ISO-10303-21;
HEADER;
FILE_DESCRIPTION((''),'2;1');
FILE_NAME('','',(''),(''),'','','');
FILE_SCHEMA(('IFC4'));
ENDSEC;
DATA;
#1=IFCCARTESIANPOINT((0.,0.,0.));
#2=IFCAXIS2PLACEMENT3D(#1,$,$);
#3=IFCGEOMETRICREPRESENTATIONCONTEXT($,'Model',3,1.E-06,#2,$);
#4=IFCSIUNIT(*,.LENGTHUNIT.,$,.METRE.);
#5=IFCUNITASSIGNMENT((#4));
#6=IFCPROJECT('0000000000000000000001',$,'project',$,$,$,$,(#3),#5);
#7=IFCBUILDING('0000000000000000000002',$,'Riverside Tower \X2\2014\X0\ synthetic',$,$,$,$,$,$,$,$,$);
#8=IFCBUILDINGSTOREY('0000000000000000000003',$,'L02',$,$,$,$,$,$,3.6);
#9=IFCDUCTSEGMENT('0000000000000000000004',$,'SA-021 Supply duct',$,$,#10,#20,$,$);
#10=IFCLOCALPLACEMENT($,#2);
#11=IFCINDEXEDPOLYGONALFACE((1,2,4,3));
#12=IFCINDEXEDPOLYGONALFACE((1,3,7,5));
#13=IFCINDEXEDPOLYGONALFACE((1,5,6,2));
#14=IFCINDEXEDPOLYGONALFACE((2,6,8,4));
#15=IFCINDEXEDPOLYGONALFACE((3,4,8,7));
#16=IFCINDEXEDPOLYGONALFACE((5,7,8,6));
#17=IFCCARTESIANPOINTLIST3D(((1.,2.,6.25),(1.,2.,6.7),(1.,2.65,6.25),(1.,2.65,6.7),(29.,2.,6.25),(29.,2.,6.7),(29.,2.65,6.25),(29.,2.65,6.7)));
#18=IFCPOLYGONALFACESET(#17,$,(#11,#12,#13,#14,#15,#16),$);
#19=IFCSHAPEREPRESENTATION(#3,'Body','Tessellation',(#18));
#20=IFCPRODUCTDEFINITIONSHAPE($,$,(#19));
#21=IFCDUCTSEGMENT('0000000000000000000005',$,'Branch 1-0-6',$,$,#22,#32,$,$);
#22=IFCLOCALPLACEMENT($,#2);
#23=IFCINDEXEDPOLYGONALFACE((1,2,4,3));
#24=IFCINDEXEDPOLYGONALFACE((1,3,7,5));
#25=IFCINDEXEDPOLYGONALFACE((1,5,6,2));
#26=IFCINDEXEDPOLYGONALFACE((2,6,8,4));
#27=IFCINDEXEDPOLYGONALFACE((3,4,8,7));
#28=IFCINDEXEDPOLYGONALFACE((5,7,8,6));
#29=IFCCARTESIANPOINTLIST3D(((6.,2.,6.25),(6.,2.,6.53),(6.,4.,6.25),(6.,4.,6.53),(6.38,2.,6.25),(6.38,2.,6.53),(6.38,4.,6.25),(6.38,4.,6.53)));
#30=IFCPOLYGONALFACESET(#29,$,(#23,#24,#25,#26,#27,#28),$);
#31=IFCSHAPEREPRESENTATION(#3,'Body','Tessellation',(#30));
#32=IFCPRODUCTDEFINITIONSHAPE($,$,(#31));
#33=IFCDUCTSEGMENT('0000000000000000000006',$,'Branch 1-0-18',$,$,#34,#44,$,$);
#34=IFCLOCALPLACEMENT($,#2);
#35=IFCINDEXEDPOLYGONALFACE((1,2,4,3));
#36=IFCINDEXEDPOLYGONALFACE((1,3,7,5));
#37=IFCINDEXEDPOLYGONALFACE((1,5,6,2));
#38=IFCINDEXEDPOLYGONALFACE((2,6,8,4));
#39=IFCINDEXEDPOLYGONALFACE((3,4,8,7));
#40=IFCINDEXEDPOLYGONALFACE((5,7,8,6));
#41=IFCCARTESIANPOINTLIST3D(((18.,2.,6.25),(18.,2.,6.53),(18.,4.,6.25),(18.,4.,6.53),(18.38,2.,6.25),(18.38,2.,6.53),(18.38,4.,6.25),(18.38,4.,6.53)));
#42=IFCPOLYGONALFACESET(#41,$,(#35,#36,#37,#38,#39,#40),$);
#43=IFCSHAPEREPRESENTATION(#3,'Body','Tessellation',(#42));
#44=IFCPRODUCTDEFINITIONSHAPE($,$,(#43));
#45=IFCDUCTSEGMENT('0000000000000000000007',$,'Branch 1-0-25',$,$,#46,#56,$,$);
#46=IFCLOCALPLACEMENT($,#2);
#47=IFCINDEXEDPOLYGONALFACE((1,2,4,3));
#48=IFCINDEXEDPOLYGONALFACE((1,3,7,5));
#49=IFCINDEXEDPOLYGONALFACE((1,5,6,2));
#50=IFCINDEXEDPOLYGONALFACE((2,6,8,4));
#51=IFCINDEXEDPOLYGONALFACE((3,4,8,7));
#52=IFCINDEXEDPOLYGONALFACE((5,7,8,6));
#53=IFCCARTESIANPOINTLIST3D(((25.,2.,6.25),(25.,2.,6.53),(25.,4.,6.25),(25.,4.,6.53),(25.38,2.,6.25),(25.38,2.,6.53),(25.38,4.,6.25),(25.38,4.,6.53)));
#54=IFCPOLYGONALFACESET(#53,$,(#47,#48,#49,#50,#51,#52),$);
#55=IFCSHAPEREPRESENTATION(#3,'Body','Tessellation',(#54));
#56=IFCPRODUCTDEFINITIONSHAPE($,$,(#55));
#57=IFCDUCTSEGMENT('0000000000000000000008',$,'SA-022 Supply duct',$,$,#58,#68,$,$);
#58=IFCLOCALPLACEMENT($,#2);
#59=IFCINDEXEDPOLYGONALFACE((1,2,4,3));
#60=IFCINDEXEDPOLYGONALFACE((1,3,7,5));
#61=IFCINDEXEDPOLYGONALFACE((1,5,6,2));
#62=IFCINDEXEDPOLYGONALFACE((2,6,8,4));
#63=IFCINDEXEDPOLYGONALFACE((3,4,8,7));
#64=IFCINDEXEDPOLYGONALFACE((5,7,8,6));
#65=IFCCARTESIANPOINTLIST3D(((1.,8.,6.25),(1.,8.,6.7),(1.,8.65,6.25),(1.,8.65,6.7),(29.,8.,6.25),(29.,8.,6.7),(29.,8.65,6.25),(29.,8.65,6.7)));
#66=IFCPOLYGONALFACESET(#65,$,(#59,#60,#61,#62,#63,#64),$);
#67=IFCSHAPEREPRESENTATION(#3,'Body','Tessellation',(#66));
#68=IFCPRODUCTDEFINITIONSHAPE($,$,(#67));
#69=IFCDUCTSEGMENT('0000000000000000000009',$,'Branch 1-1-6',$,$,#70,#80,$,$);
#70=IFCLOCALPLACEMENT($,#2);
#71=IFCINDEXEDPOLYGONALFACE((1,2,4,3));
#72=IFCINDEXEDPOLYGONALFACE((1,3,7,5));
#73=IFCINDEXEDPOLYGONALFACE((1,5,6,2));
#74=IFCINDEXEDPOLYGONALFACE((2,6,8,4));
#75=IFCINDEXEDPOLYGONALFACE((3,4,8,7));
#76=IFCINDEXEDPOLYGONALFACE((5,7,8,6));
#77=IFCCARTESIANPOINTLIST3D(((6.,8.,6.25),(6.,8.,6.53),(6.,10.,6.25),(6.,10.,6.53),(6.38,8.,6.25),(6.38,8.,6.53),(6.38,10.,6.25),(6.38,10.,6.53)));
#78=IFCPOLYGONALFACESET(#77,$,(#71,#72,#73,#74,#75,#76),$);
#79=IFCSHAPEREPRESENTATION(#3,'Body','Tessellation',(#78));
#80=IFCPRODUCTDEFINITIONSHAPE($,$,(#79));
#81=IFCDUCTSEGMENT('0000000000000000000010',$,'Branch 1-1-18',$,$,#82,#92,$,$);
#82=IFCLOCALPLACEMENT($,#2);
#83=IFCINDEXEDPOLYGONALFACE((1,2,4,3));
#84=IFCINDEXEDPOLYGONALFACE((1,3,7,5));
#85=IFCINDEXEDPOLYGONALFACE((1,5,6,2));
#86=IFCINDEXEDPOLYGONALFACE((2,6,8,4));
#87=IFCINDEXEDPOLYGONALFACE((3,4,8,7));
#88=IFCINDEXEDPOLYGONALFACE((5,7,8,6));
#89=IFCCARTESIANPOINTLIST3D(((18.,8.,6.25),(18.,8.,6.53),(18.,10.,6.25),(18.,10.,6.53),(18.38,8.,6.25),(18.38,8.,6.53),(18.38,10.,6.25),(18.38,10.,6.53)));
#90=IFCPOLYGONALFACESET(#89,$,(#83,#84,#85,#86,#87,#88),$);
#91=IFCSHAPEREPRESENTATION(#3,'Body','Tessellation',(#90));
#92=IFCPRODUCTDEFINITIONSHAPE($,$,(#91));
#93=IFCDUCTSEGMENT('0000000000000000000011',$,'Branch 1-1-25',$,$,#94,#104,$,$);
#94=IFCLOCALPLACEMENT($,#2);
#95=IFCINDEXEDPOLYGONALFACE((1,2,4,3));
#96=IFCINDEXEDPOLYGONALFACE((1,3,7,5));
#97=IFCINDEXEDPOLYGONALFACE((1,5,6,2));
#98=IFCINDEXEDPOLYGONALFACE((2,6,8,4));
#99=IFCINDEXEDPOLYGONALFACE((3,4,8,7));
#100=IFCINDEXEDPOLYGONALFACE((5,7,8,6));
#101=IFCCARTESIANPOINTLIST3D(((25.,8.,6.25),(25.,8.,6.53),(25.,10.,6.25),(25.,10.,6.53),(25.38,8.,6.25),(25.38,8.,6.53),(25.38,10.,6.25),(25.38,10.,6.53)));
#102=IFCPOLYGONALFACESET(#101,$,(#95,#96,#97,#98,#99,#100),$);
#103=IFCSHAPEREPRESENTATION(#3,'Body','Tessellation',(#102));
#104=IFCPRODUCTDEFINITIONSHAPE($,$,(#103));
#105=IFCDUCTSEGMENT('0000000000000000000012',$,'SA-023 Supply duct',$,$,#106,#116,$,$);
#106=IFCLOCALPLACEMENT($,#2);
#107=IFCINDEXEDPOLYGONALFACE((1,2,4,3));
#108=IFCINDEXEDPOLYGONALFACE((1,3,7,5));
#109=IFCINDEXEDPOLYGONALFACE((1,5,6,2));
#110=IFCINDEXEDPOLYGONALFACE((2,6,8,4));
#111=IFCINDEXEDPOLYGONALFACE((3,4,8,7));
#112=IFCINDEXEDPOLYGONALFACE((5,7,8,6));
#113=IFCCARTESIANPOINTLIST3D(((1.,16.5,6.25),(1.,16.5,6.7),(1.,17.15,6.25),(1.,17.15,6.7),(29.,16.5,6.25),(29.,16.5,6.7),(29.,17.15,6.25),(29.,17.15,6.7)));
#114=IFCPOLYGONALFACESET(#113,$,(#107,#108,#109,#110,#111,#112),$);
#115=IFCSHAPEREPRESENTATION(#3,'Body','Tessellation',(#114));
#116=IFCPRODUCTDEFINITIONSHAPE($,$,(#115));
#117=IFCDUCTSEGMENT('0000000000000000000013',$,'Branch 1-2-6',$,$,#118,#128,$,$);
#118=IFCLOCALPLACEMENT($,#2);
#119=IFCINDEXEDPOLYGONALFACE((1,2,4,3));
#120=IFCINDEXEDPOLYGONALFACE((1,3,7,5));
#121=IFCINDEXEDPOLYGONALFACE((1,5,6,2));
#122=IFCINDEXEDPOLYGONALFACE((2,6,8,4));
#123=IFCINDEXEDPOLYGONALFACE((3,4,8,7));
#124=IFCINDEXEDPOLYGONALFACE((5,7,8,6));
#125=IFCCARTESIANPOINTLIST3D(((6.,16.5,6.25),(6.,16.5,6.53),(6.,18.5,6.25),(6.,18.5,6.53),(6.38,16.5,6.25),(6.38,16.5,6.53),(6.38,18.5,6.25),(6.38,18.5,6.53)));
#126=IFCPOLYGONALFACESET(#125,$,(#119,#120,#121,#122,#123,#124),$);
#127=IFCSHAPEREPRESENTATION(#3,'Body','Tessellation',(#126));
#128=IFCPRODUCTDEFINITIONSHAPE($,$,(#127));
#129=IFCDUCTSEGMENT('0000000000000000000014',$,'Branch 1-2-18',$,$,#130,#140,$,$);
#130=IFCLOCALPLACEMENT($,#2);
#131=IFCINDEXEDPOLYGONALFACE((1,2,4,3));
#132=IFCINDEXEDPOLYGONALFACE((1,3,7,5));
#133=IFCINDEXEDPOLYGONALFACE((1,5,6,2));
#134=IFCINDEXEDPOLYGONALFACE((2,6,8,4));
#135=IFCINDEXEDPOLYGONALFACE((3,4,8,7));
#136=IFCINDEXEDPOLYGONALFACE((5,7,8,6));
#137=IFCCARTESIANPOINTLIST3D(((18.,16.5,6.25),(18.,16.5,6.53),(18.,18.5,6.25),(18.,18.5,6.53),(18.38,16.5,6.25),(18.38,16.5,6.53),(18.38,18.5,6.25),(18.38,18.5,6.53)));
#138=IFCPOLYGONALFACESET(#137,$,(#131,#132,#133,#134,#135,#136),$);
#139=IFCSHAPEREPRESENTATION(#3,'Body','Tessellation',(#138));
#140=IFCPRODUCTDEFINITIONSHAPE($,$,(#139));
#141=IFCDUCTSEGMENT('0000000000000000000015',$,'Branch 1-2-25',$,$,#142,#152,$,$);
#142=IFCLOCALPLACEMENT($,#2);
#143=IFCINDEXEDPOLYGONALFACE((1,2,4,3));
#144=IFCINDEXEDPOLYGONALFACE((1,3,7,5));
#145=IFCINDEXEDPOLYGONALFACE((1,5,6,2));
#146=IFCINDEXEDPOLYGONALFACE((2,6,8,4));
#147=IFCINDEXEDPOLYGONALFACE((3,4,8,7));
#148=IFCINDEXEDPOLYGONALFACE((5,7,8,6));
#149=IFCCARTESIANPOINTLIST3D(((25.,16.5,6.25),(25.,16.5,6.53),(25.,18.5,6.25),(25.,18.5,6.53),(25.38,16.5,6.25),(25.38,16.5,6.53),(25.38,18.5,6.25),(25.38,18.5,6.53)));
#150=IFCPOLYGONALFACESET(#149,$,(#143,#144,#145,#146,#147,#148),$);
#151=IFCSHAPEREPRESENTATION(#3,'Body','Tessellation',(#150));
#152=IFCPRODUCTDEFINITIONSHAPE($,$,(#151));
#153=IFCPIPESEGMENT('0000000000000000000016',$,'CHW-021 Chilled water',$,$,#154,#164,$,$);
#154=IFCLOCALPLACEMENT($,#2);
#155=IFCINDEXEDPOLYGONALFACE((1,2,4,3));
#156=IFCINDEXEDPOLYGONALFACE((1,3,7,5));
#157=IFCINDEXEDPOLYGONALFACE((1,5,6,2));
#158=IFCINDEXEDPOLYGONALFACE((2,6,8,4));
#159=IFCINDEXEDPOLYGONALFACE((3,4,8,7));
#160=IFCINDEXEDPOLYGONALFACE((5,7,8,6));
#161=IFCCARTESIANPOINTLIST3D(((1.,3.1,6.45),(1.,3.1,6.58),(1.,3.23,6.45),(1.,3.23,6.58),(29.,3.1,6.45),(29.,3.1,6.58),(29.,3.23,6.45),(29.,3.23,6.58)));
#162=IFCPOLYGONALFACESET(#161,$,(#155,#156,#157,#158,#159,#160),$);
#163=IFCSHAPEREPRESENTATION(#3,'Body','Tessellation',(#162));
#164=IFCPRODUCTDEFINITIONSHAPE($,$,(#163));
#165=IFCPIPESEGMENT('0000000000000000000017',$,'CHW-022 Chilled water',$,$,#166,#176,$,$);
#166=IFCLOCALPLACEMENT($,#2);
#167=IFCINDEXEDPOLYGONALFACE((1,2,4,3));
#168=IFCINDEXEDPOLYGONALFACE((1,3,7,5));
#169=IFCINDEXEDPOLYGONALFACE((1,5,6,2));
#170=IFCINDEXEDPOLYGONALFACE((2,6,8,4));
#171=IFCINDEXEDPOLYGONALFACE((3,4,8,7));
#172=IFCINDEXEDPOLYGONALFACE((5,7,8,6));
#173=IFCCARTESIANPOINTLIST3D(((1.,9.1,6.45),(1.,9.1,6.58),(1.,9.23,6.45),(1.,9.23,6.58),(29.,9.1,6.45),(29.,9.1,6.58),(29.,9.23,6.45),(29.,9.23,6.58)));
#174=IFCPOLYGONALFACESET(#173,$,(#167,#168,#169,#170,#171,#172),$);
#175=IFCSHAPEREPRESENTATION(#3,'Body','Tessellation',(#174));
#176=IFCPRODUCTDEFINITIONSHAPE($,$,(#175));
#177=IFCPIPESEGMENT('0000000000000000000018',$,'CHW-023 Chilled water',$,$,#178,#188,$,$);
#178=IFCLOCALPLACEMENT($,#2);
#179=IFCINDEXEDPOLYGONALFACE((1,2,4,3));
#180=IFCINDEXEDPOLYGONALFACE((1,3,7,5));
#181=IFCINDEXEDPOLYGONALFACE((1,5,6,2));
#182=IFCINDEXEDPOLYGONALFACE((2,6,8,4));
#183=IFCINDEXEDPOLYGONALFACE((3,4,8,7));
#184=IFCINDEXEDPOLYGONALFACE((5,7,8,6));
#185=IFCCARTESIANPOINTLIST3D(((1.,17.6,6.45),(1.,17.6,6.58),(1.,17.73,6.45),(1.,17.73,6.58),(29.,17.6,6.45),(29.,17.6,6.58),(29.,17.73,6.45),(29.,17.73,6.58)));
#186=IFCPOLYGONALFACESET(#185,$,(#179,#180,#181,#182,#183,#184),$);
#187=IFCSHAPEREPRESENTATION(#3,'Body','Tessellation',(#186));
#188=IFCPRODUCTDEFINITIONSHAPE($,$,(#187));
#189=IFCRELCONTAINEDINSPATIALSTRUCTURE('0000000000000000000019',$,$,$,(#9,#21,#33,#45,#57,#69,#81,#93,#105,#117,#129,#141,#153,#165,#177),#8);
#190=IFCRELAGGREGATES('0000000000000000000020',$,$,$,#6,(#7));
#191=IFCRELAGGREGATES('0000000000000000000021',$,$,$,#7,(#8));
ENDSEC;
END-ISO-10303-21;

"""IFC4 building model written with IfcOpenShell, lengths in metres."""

from ifc_helpers import new_model, si_unit, frame, origin, place, context, project, spatial, rectangle, extrude, element, save


model = new_model("IFC4")

# Units and contexts
model_context = context("Model", 3, precision=1e-06, world=origin())
ifc_project = project(units=[si_unit("LENGTHUNIT", "METRE")], contexts=[model_context])

# Building, storey
building = spatial("IfcBuilding", under=ifc_project, Name="Riverside Tower — synthetic")
storey = spatial("IfcBuildingStorey", under=building, Name="L02", Elevation=3.6)

# Duct segments
duct_segment_1_placement = place(None, frame((15.0, 2.325, 6.25)))
element("IfcDuctSegment", 1, at=duct_segment_1_placement, inside=storey, Name="SA-021 Supply duct", context=model_context, shape_type="SweptSolid", body=[
    extrude(rectangle(XDim=28.0, YDim=0.65), origin(), (0.0, 0.0, 1.0), 0.45),
])
for number, where, name in (
    (2, (6.19, 3.0, 6.25), "Branch 1-0-6"),
    (3, (18.19, 3.0, 6.25), "Branch 1-0-18"),
    (4, (25.19, 3.0, 6.25), "Branch 1-0-25"),
):
    element("IfcDuctSegment", number, at=place(None, frame(where)), inside=storey, Name=name, context=model_context, shape_type="SweptSolid", body=[
        extrude(rectangle(XDim=0.38, YDim=2.0), origin(), (0.0, 0.0, 1.0), 0.28),
    ])
duct_segment_2_placement = place(None, frame((15.0, 8.325, 6.25)))
element("IfcDuctSegment", 5, at=duct_segment_2_placement, inside=storey, Name="SA-022 Supply duct", context=model_context, shape_type="SweptSolid", body=[
    extrude(rectangle(XDim=28.0, YDim=0.65), origin(), (0.0, 0.0, 1.0), 0.45),
])
for number, where, name in (
    (6, (6.19, 9.0, 6.25), "Branch 1-1-6"),
    (7, (18.19, 9.0, 6.25), "Branch 1-1-18"),
    (8, (25.19, 9.0, 6.25), "Branch 1-1-25"),
):
    element("IfcDuctSegment", number, at=place(None, frame(where)), inside=storey, Name=name, context=model_context, shape_type="SweptSolid", body=[
        extrude(rectangle(XDim=0.38, YDim=2.0), origin(), (0.0, 0.0, 1.0), 0.28),
    ])
duct_segment_3_placement = place(None, frame((15.0, 16.825, 6.25)))
element("IfcDuctSegment", 9, at=duct_segment_3_placement, inside=storey, Name="SA-023 Supply duct", context=model_context, shape_type="SweptSolid", body=[
    extrude(rectangle(XDim=28.0, YDim=0.65), origin(), (0.0, 0.0, 1.0), 0.45),
])
for number, where, name in (
    (10, (6.19, 17.5, 6.25), "Branch 1-2-6"),
    (11, (18.19, 17.5, 6.25), "Branch 1-2-18"),
    (12, (25.19, 17.5, 6.25), "Branch 1-2-25"),
):
    element("IfcDuctSegment", number, at=place(None, frame(where)), inside=storey, Name=name, context=model_context, shape_type="SweptSolid", body=[
        extrude(rectangle(XDim=0.38, YDim=2.0), origin(), (0.0, 0.0, 1.0), 0.28),
    ])

# Pipe segments
for number, where, name in (
    (13, (15.0, 3.165, 6.45), "CHW-021 Chilled water"),
    (14, (15.0, 9.165, 6.45), "CHW-022 Chilled water"),
    (15, (15.0, 17.665, 6.45), "CHW-023 Chilled water"),
):
    element("IfcPipeSegment", number, at=place(None, frame(where)), inside=storey, Name=name, context=model_context, shape_type="SweptSolid", body=[
        extrude(rectangle(XDim=28.0, YDim=0.13), origin(), (0.0, 0.0, 1.0), 0.13),
    ])

save(model, "model.ifc")
